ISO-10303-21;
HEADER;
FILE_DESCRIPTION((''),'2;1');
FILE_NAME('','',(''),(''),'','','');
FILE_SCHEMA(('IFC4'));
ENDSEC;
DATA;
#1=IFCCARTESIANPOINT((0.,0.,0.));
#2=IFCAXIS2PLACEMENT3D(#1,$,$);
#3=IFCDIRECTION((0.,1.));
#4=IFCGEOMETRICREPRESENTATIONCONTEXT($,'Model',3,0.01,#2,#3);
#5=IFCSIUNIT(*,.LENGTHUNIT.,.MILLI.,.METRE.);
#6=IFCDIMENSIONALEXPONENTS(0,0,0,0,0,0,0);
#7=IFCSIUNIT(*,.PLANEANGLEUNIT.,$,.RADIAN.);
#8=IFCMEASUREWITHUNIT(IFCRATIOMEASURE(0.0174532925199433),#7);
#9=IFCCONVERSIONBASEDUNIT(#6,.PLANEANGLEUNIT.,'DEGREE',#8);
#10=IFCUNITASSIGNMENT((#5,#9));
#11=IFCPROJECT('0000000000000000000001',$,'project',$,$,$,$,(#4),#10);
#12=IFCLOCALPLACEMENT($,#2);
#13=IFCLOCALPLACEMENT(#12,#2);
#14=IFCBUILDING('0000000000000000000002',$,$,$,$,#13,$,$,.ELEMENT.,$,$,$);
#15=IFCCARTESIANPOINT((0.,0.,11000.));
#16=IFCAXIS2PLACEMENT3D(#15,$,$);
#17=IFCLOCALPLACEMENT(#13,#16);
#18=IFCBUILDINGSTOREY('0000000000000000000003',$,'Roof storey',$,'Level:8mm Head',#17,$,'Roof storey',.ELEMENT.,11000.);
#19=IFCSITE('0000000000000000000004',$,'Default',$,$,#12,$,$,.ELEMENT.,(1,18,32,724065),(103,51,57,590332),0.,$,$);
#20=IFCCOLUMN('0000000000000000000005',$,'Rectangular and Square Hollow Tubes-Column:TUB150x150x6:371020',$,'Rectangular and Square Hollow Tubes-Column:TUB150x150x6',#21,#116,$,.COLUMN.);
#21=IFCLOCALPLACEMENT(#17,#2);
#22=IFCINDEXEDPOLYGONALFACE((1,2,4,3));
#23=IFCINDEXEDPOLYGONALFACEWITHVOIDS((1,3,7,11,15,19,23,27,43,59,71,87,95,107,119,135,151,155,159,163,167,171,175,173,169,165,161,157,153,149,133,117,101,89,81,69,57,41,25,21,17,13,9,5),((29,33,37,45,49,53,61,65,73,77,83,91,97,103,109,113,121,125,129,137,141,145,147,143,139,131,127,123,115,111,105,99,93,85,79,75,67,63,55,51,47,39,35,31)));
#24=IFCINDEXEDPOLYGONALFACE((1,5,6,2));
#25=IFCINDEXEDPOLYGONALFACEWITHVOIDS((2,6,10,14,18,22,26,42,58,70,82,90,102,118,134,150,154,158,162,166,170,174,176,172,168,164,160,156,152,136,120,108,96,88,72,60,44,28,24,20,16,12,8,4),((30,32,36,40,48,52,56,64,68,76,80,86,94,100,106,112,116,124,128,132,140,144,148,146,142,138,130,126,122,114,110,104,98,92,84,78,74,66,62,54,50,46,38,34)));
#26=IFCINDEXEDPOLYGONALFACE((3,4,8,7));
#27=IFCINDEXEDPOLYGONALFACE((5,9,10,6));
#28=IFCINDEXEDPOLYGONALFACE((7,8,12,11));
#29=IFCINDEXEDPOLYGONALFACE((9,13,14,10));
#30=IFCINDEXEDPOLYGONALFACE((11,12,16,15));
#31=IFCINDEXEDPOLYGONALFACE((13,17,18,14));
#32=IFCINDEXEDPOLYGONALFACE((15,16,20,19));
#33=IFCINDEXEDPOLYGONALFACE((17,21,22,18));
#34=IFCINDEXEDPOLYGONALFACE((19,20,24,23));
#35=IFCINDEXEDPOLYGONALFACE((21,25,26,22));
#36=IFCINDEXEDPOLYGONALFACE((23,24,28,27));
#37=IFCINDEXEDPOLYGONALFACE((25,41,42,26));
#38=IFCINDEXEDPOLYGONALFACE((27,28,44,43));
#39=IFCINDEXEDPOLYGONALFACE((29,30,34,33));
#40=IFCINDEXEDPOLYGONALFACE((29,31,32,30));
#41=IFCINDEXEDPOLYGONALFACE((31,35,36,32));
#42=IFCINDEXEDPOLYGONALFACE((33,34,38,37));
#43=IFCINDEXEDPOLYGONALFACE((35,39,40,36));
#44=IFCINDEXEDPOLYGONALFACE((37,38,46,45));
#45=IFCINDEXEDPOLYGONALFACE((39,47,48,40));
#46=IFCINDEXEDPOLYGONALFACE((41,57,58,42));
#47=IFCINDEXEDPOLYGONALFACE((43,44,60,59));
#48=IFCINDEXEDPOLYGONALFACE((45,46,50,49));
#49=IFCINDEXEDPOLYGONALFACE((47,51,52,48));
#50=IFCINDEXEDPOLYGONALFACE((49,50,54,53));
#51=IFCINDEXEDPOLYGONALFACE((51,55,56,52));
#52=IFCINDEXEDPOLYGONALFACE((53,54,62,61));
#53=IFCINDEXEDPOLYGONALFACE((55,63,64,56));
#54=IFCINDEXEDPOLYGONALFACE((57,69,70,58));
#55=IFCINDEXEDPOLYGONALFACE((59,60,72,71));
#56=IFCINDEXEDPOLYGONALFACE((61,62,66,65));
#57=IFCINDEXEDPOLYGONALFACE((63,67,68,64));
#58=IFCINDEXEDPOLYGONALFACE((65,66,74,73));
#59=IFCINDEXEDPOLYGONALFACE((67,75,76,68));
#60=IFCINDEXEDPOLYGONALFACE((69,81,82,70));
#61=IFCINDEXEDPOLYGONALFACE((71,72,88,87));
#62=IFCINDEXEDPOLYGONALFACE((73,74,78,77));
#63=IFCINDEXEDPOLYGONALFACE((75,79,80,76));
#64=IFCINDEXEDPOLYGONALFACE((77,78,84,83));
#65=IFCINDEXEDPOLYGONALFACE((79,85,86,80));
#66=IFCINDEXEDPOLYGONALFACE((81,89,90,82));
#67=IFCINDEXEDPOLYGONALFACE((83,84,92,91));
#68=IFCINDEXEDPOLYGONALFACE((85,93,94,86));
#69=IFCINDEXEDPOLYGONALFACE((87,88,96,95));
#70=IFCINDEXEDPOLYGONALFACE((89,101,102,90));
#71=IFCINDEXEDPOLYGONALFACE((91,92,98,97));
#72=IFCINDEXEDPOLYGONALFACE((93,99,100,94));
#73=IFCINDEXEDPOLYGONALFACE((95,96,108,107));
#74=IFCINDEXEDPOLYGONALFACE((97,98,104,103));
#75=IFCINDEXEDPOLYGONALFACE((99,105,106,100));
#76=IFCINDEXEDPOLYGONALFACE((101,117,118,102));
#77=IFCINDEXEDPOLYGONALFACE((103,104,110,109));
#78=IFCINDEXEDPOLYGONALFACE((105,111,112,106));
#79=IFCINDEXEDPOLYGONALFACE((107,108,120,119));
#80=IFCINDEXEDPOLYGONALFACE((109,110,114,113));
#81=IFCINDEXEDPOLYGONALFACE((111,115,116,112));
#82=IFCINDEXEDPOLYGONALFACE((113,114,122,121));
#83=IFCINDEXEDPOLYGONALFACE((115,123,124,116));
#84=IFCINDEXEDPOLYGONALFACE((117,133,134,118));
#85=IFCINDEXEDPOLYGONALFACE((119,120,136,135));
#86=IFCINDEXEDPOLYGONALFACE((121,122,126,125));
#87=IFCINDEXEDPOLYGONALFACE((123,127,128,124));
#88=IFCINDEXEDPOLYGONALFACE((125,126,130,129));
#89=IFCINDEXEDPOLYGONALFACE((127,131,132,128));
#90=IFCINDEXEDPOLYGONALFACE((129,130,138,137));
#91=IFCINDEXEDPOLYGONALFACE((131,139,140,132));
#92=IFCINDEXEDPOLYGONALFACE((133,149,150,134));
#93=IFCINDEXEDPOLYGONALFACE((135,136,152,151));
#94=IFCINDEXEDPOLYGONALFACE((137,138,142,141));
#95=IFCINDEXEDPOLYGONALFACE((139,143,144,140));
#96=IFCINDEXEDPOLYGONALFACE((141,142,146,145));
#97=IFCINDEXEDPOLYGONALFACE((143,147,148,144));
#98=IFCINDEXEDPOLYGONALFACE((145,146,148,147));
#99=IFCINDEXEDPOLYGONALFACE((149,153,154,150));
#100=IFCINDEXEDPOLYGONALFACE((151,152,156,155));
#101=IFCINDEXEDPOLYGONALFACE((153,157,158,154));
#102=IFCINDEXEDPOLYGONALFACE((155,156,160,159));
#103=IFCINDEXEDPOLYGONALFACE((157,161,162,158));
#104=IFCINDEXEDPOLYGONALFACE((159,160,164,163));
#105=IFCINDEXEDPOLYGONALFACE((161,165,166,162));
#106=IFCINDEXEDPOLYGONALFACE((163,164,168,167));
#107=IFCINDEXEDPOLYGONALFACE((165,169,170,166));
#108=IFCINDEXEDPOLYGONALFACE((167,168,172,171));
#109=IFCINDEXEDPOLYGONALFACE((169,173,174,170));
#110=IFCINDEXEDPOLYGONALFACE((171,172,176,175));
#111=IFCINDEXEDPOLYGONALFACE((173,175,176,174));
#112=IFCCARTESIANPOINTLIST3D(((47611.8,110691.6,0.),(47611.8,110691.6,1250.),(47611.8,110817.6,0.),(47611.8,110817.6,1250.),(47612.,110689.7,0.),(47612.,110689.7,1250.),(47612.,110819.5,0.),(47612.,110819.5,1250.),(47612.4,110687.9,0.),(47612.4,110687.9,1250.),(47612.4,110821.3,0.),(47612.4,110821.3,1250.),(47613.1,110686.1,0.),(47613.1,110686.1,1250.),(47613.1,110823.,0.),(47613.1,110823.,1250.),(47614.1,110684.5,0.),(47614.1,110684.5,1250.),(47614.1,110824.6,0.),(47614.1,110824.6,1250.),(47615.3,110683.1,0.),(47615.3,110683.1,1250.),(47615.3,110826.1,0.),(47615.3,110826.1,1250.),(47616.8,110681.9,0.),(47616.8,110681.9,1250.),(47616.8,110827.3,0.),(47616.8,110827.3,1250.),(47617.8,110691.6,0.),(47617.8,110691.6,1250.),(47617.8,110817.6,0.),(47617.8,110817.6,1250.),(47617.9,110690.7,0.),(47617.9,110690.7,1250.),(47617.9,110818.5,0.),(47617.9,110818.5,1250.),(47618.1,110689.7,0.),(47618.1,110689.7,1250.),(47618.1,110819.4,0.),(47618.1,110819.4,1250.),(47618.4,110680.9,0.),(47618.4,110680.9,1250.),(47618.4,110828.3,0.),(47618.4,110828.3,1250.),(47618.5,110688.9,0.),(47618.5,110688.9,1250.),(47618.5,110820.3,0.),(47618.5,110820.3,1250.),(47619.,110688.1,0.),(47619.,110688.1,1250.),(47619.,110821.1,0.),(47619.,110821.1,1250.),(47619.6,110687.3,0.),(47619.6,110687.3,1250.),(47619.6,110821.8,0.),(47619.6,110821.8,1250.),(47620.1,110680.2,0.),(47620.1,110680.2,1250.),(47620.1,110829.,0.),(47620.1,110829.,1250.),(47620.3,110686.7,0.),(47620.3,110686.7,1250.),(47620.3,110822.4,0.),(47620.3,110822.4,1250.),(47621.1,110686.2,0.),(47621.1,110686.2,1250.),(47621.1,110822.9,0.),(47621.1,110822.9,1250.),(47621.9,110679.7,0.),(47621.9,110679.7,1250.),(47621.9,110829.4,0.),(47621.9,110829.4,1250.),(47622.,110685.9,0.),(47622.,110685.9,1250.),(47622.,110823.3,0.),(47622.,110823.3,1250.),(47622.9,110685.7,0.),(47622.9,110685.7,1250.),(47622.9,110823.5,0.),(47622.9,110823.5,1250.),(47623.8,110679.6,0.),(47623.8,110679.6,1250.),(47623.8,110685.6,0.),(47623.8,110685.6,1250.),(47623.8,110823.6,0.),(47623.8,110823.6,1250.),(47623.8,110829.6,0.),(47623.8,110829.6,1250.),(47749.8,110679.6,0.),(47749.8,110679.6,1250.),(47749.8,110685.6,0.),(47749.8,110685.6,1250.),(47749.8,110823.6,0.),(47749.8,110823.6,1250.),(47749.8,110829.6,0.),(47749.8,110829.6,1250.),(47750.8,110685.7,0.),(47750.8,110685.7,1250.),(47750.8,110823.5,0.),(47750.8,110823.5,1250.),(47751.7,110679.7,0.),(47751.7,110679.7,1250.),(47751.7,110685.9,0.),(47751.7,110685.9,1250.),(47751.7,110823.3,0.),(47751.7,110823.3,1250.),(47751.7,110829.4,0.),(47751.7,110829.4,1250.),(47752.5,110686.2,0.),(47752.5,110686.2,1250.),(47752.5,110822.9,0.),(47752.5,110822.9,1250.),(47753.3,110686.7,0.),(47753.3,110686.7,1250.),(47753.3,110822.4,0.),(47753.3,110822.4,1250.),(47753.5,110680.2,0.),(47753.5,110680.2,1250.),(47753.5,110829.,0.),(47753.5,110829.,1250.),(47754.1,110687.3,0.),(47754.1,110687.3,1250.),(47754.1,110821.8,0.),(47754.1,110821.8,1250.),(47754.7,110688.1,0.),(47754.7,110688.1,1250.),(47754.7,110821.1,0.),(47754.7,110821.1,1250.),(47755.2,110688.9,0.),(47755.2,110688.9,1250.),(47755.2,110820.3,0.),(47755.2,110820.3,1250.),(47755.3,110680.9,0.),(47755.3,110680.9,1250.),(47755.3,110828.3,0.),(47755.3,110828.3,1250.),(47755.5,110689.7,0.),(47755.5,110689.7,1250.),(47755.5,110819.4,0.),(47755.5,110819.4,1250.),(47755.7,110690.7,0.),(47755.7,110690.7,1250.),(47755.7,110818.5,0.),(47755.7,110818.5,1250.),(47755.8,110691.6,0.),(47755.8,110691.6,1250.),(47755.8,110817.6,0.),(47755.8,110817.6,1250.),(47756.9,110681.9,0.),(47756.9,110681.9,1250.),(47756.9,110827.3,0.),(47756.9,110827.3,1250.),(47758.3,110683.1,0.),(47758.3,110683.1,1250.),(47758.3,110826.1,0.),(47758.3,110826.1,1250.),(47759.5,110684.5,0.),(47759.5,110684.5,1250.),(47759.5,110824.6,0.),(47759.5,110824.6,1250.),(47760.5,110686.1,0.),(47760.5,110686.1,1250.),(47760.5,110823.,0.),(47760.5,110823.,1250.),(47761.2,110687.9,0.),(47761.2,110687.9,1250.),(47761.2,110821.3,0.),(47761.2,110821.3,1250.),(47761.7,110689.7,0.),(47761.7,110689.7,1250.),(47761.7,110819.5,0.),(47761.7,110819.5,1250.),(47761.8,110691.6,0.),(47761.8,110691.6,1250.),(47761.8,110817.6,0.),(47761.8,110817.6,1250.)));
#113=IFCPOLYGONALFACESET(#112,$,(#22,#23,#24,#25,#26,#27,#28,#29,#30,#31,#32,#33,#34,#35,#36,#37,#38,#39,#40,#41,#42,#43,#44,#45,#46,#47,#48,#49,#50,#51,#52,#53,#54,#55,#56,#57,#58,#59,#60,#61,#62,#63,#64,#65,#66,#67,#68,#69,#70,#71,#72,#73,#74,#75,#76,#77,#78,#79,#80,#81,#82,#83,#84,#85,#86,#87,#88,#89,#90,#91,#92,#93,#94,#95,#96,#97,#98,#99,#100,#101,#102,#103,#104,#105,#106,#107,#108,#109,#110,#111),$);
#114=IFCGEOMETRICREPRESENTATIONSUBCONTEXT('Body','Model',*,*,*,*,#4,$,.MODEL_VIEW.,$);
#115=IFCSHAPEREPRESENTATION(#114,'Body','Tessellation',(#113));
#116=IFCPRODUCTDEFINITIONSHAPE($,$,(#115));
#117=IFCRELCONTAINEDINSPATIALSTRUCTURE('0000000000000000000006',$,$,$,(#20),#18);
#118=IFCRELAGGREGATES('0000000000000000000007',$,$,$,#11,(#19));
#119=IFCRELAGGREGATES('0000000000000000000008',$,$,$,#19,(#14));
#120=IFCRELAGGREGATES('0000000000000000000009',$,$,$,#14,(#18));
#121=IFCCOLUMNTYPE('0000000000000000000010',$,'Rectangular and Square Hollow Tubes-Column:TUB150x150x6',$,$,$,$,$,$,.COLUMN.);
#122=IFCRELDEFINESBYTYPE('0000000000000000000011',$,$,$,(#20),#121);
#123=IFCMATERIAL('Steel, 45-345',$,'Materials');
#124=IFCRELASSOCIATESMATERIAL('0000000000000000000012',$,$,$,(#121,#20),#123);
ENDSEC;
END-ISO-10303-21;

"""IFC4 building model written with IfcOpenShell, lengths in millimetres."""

from ifc_helpers import new_model, entity, si_unit, converted_unit, direction, frame, origin, place, context, subcontext, project, spatial, indexed_curve, outline, extrude, source, transform, mapped, material, type_object, type_shapes, element, save


model = new_model("IFC4")

# Units and contexts
model_context = context("Model", 3, precision=0.01, world=origin(), true_north=direction((0.0, 1.0)))
body_context = subcontext(model_context, "Body", "Model", "MODEL_VIEW")
ifc_project = project(units=[si_unit("LENGTHUNIT", "METRE", prefix="MILLI"), converted_unit("PLANEANGLEUNIT", "DEGREE", entity("IfcRatioMeasure", 0.0174532925199433), si_unit("PLANEANGLEUNIT", "RADIAN"), dimensions=[0, 0, 0, 0, 0, 0, 0])], contexts=[model_context])

# Site, building, storey
site_placement = place(None, origin())
site = spatial("IfcSite", under=ifc_project, at=site_placement, Name="Default", CompositionType="ELEMENT", RefLatitude=(1, 18, 32, 724065), RefLongitude=(103, 51, 57, 590332), RefElevation=0.0)
building_placement = place(site_placement, origin())
building = spatial("IfcBuilding", under=site, at=building_placement, CompositionType="ELEMENT")
storey_placement = place(building_placement, frame((0.0, 0.0, 11000.0)))
storey = spatial("IfcBuildingStorey", under=building, at=storey_placement, Name="Roof storey", ObjectType="Level:8mm Head", LongName="Roof storey", CompositionType="ELEMENT", Elevation=11000.0)

# Column
ifc_material = material(Name="Steel, 45-345", Category="Materials")
column_type = type_object("IfcColumnType", Name="Rectangular and Square Hollow Tubes-Column:TUB150x150x6", PredefinedType="COLUMN", material=ifc_material)
shared_shape_1 = source(origin(), body_context, "Body", "SweptSolid", [
    extrude(outline(indexed_curve([(-63.0, -75.0), (63.0, -75.0), (64.9, -74.9), (66.7, -74.4), (68.4, -73.7), (70.1, -72.7), (71.5, -71.5), (72.7, -70.1), (73.7, -68.4), (74.4, -66.7), (74.9, -64.9), (75.0, -63.0), (75.0, 63.0), (74.9, 64.9), (74.4, 66.7), (73.7, 68.4), (72.7, 70.1), (71.5, 71.5), (70.1, 72.7), (68.4, 73.7), (66.7, 74.4), (64.9, 74.9), (63.0, 75.0), (-63.0, 75.0), (-64.9, 74.9), (-66.7, 74.4), (-68.4, 73.7), (-70.1, 72.7), (-71.5, 71.5), (-72.7, 70.1), (-73.7, 68.4), (-74.4, 66.7), (-74.9, 64.9), (-75.0, 63.0), (-75.0, -63.0), (-74.9, -64.9), (-74.4, -66.7), (-73.7, -68.4), (-72.7, -70.1), (-71.5, -71.5), (-70.1, -72.7), (-68.4, -73.7), (-66.7, -74.4), (-64.9, -74.9), (-63.0, -75.0)], self_intersect=False), holes=[indexed_curve([(-63.0, -69.0), (-63.9, -68.9), (-64.9, -68.7), (-65.7, -68.3), (-66.5, -67.9), (-67.2, -67.2), (-67.9, -66.5), (-68.3, -65.7), (-68.7, -64.9), (-68.9, -63.9), (-69.0, -63.0), (-69.0, 63.0), (-68.9, 63.9), (-68.7, 64.9), (-68.3, 65.7), (-67.9, 66.5), (-67.2, 67.2), (-66.5, 67.9), (-65.7, 68.3), (-64.9, 68.7), (-63.9, 68.9), (-63.0, 69.0), (63.0, 69.0), (63.9, 68.9), (64.9, 68.7), (65.7, 68.3), (66.5, 67.9), (67.2, 67.2), (67.9, 66.5), (68.3, 65.7), (68.7, 64.9), (68.9, 63.9), (69.0, 63.0), (69.0, -63.0), (68.9, -63.9), (68.7, -64.9), (68.3, -65.7), (67.9, -66.5), (67.2, -67.2), (66.5, -67.9), (65.7, -68.3), (64.9, -68.7), (63.9, -68.9), (63.0, -69.0), (-63.0, -69.0)], self_intersect=False)]), frame((0.0, 0.0, 11000.0), z_axis=(0.0, 0.0, 1.0), x_axis=(-1.0, 0.0, 0.0)), (0.0, 0.0, 1.0), 1250.0),
])
type_shapes(column_type, [shared_shape_1])
for number, where, name in (
    (1, (47686.8, 110754.6, -11000.0), "Rectangular and Square Hollow Tubes-Column:TUB150x150x6:371020"),
):
    element("IfcColumn", number, at=place(storey_placement, frame(where)), inside=storey, type_object=column_type, material=ifc_material, Name=name, ObjectType="Rectangular and Square Hollow Tubes-Column:TUB150x150x6", PredefinedType="COLUMN", context=body_context, shape_type="MappedRepresentation", body=[
        mapped(shared_shape_1, transform((0.0, 0.0, 0.0), scale=1.0)),
    ])

save(model, "model.ifc")
